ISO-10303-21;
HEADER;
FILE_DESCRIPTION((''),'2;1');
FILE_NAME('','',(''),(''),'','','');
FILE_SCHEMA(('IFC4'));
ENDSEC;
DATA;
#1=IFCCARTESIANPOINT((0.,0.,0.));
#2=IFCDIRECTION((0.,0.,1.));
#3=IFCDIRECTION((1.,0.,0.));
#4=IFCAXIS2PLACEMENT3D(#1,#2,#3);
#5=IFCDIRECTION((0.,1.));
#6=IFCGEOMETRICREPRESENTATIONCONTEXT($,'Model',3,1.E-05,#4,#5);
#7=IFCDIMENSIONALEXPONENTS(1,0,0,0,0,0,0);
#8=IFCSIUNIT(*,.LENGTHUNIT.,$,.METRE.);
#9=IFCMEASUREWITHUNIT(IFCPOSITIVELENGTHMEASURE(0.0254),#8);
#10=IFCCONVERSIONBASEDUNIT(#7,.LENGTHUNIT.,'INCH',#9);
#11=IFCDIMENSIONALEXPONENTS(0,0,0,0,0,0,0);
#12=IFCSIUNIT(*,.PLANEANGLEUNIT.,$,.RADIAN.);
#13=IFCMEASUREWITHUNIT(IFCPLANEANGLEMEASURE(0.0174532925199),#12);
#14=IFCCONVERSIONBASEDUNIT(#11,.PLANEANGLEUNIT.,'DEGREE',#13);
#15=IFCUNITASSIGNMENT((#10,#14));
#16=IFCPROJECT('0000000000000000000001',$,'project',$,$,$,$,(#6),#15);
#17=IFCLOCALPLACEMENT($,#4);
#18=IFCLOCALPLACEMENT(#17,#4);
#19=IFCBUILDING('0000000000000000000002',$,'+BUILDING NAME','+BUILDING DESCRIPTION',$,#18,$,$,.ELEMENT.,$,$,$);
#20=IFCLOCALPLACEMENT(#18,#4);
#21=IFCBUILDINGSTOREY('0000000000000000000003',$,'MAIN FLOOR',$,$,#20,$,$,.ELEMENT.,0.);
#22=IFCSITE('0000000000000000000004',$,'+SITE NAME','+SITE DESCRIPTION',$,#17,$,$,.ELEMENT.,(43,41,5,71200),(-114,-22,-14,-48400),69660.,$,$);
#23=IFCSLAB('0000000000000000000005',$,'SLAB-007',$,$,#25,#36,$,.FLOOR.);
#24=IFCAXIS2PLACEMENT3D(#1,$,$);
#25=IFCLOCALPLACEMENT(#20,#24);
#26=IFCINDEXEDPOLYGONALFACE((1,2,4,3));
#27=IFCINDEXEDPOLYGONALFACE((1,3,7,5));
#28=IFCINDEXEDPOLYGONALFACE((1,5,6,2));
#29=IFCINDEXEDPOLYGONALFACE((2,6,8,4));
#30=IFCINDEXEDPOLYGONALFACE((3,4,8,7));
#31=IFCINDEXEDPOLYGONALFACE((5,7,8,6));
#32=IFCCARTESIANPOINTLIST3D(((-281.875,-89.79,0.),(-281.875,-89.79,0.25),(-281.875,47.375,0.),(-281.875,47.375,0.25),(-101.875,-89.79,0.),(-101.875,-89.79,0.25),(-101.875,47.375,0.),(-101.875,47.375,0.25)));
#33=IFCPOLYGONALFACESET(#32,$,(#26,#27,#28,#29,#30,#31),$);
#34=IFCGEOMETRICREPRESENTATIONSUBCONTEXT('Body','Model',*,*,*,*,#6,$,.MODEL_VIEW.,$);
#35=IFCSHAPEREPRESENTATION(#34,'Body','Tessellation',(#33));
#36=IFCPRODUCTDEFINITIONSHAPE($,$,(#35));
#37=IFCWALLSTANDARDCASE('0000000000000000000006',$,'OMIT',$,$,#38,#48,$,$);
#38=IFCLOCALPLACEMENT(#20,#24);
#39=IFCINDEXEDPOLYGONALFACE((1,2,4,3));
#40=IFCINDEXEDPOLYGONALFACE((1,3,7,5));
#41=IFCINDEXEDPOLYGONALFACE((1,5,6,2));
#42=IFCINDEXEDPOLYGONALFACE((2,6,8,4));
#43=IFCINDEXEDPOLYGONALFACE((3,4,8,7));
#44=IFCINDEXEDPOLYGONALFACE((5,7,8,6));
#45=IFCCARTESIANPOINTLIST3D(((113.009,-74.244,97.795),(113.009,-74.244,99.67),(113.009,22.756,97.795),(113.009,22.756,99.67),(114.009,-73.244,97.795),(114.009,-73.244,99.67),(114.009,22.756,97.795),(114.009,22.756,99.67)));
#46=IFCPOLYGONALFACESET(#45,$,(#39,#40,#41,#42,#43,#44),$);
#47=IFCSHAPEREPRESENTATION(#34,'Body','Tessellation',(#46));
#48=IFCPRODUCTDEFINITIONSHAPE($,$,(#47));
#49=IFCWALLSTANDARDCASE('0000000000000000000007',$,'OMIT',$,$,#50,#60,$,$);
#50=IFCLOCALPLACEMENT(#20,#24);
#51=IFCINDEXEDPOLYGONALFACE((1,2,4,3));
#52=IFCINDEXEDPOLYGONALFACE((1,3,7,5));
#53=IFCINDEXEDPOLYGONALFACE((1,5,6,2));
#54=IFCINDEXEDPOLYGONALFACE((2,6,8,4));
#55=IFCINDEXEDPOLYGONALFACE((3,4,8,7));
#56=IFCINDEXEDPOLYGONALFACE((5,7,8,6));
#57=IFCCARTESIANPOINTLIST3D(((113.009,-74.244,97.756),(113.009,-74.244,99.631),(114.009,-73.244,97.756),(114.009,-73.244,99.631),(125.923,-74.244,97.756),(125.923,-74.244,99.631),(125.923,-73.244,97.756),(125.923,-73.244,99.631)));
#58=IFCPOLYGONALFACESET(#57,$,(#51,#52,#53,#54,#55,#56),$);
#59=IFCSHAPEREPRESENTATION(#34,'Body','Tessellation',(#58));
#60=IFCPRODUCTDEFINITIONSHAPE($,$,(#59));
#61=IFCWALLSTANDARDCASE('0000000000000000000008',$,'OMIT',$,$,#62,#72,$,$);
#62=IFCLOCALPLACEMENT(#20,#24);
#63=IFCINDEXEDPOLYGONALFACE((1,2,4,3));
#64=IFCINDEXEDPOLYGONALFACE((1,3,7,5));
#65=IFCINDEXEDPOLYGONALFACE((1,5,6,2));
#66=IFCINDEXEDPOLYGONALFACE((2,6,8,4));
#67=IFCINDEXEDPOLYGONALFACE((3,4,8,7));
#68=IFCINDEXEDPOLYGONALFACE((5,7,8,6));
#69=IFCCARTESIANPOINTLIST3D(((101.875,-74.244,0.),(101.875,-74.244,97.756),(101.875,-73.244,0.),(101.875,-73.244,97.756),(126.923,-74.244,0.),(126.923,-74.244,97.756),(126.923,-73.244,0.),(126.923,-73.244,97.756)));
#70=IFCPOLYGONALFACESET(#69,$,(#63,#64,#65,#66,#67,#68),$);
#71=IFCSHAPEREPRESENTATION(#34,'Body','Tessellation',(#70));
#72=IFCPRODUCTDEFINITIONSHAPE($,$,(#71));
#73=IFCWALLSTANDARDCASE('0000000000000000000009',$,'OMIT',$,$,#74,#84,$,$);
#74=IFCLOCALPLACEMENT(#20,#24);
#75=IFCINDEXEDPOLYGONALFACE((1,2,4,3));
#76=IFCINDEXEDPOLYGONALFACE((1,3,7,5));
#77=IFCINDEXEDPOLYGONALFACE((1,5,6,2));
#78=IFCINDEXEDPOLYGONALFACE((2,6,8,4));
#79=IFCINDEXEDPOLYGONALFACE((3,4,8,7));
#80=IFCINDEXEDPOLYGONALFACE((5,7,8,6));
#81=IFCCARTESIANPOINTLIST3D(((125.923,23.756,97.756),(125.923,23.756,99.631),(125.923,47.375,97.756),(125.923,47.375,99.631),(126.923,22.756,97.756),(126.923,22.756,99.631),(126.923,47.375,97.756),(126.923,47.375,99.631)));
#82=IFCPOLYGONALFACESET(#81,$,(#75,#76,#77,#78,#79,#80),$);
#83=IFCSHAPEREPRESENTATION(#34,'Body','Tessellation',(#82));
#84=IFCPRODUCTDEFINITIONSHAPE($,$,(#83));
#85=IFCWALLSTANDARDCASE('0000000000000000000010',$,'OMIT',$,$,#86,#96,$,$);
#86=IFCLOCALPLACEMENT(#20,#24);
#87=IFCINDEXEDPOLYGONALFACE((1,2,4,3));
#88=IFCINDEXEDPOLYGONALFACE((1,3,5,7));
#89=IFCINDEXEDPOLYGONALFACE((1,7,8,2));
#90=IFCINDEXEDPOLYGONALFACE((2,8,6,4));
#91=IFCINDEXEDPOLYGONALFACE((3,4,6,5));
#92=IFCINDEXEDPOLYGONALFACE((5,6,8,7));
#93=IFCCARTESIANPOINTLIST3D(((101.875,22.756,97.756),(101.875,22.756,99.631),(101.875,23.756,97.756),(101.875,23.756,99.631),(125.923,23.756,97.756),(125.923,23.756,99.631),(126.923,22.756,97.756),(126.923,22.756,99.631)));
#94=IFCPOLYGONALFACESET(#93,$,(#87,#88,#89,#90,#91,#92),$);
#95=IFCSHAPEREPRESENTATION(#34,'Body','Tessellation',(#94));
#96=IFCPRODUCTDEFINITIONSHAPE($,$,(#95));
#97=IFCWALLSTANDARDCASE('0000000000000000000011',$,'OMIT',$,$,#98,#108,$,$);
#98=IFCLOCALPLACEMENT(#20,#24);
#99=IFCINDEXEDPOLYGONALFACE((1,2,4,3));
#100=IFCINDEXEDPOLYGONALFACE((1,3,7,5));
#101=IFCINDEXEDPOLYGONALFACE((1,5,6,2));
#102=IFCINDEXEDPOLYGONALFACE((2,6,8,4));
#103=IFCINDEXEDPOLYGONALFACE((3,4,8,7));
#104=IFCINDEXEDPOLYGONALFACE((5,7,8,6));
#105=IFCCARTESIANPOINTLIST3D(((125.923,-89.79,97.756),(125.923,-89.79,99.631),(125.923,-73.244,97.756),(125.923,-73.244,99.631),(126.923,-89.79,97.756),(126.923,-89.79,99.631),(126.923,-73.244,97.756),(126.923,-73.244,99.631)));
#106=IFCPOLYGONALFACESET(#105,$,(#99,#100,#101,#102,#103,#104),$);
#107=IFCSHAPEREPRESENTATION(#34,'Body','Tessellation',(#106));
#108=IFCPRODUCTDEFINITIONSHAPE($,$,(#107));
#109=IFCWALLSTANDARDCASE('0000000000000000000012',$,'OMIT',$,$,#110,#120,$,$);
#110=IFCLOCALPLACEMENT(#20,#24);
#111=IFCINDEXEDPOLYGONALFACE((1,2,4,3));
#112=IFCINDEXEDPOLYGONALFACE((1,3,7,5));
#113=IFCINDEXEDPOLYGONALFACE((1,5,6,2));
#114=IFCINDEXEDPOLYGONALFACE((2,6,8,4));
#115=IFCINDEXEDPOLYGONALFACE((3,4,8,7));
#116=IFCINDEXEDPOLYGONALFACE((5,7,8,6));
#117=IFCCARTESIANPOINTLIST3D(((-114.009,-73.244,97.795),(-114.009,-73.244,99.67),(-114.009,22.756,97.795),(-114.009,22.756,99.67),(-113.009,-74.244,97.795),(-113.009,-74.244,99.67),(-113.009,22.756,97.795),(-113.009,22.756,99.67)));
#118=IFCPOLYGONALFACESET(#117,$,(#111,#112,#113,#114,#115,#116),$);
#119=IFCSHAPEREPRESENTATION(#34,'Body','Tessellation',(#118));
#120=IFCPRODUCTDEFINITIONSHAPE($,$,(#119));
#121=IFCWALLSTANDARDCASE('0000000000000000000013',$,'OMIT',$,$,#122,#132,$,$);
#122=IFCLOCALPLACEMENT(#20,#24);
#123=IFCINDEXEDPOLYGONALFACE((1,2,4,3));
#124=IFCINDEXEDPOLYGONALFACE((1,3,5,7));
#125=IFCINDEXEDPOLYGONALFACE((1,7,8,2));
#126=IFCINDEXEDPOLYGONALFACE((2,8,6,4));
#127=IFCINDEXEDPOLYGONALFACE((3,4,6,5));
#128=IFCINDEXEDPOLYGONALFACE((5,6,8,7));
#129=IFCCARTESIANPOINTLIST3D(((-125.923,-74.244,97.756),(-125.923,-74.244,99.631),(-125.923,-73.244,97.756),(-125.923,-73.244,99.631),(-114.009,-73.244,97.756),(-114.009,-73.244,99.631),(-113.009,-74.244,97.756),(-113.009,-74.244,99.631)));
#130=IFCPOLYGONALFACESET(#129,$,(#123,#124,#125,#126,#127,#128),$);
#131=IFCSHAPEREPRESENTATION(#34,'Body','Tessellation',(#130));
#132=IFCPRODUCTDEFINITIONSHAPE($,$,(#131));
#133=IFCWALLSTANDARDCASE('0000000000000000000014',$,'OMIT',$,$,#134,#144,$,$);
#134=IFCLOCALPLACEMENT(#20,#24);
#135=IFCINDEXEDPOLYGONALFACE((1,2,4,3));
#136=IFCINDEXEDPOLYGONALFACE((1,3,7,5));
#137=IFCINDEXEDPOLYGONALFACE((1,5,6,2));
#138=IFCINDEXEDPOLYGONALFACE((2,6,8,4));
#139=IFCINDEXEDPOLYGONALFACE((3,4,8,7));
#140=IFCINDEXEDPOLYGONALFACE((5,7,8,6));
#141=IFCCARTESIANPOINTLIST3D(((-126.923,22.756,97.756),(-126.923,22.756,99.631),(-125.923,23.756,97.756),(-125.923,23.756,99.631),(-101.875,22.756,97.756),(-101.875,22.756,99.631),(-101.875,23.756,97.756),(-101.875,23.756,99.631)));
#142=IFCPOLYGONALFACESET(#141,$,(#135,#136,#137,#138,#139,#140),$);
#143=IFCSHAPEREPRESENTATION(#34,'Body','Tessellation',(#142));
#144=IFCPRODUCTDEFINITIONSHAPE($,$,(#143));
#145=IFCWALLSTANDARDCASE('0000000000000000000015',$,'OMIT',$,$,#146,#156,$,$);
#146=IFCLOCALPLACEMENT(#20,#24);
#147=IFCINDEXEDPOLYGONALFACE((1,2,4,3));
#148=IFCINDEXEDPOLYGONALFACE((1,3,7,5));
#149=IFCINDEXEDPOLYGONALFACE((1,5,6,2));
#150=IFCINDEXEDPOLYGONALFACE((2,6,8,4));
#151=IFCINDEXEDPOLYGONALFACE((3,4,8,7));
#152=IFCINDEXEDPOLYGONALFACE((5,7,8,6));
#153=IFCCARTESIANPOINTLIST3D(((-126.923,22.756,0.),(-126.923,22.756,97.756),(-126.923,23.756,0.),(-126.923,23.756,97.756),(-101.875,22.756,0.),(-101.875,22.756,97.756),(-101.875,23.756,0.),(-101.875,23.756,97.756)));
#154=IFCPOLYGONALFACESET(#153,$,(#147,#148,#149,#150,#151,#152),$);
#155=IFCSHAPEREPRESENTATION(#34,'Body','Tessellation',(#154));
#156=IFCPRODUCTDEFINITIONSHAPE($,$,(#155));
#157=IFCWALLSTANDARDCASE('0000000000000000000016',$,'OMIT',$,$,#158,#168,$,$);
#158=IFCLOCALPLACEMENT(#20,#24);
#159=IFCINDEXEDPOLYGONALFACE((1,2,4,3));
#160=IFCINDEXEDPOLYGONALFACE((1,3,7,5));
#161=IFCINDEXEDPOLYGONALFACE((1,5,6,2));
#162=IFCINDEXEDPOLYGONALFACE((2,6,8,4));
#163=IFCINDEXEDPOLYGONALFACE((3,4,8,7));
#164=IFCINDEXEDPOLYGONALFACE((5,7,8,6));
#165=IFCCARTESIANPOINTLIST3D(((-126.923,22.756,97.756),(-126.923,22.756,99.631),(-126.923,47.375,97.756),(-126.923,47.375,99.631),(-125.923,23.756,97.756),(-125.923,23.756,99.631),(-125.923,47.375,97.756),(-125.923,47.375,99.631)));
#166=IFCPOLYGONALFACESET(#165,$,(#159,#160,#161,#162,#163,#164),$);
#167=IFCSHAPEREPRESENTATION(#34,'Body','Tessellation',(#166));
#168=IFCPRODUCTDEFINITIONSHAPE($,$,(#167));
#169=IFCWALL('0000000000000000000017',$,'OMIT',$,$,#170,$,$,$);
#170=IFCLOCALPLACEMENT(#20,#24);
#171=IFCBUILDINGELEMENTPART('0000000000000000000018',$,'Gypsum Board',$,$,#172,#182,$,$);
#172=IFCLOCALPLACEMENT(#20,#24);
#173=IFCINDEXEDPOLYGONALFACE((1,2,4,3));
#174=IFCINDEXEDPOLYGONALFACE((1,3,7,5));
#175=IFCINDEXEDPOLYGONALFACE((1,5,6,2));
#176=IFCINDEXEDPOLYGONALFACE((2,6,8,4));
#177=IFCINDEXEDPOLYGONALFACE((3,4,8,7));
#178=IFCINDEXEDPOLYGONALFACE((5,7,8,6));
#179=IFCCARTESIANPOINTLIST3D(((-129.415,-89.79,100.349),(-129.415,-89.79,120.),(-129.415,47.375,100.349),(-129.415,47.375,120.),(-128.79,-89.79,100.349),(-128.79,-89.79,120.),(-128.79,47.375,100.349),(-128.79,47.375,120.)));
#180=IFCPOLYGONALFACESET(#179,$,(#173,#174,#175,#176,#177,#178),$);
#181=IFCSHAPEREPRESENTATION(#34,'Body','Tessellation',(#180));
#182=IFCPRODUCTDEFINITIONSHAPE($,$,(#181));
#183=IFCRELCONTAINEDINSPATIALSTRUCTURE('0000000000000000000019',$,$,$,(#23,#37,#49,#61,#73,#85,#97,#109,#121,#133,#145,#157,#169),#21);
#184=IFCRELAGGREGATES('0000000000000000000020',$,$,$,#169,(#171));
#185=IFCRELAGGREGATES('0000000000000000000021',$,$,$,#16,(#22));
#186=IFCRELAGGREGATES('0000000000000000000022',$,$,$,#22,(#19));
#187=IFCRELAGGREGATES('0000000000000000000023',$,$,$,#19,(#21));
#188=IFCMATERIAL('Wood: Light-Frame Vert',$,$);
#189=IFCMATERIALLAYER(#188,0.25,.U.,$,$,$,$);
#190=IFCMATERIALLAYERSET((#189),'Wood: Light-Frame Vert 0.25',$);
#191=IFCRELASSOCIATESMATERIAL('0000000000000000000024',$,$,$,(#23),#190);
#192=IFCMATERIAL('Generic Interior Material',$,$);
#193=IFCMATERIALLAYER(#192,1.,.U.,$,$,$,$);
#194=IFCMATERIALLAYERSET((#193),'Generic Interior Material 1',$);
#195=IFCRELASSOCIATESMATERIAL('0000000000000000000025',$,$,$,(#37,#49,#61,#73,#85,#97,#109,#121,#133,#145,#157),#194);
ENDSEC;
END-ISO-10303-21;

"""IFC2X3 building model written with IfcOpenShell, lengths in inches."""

from ifc_helpers import new_model, entity, si_unit, converted_unit, direction, frame, origin_with_axes, place, context, subcontext, project, spatial, polyline, outline, extrude, material, layer, layer_set, layer_usage, element, aggregate, save


model = new_model("IFC2X3")

# Units and contexts
model_context = context("Model", 3, precision=1e-05, world=origin_with_axes(), true_north=direction((0.0, 1.0)))
body_context = subcontext(model_context, "Body", "Model", "MODEL_VIEW")
ifc_project = project(units=[converted_unit("LENGTHUNIT", "INCH", entity("IfcPositiveLengthMeasure", 0.0254), si_unit("LENGTHUNIT", "METRE"), dimensions=[1, 0, 0, 0, 0, 0, 0]), converted_unit("PLANEANGLEUNIT", "DEGREE", entity("IfcPlaneAngleMeasure", 0.0174532925199), si_unit("PLANEANGLEUNIT", "RADIAN"), dimensions=[0, 0, 0, 0, 0, 0, 0])], contexts=[model_context])

# Site, building, storey
site_placement = place(None, origin_with_axes())
site = spatial("IfcSite", under=ifc_project, at=site_placement, Name="+SITE NAME", Description="+SITE DESCRIPTION", CompositionType="ELEMENT", RefLatitude=(43, 41, 5, 71200), RefLongitude=(-114, -22, -14, -48400), RefElevation=69660.0)
building_placement = place(site_placement, origin_with_axes())
building = spatial("IfcBuilding", under=site, at=building_placement, Name="+BUILDING NAME", Description="+BUILDING DESCRIPTION", CompositionType="ELEMENT")
storey_placement = place(building_placement, origin_with_axes())
storey = spatial("IfcBuildingStorey", under=building, at=storey_placement, Name="MAIN FLOOR", CompositionType="ELEMENT", Elevation=0.0)

# Slab
ifc_material_1 = material(Name="Wood: Light-Frame Vert")
ifc_layer_1 = layer(ifc_material_1, 0.25, ventilated="UNKNOWN")
ifc_layer_set_1 = layer_set([ifc_layer_1], Name="Wood: Light-Frame Vert 0.25")
ifc_layer_usage_1 = layer_usage(ifc_layer_set_1, "AXIS3", "NEGATIVE", 0.25)
slab_placement = place(storey_placement, frame((-281.875, -89.79, 0.25), z_axis=(0.0, 0.0, 1.0), x_axis=(1.0, 0.0, 0.0)))
element("IfcSlab", 1, at=slab_placement, inside=storey, material=ifc_layer_usage_1, Name="SLAB-007", PredefinedType="FLOOR", context=body_context, shape_type="SweptSolid", body=[
    extrude(outline(polyline([(0.0, 0.0), (180.0, 0.0), (180.0, 137.165), (0.0, 137.165), (0.0, 0.0)])), frame((0.0, 0.0, -0.25), z_axis=(0.0, 0.0, 1.0), x_axis=(1.0, 0.0, 0.0)), (0.0, 0.0, 1.0), 0.25),
])

# Walls
ifc_material_2 = material(Name="Generic Interior Material")
ifc_layer_2 = layer(ifc_material_2, 1.0, ventilated="UNKNOWN")
ifc_layer_set_2 = layer_set([ifc_layer_2], Name="Generic Interior Material 1")
ifc_layer_usage_2 = layer_usage(ifc_layer_set_2, "AXIS2", "NEGATIVE", 0.0)
wall_1_placement = place(storey_placement, frame((114.009, 22.756, 97.795), z_axis=(0.0, 0.0, 1.0), x_axis=(0.0, -1.0, 0.0)))
element("IfcWallStandardCase", 2, at=wall_1_placement, inside=storey, material=ifc_layer_usage_2, Name="OMIT", context=body_context, shape_type="SweptSolid", body=[
    extrude(outline(polyline([(0.0, -1.0), (97.0, -1.0), (96.0, 0.0), (0.0, 0.0), (0.0, -1.0)])), origin_with_axes(), (0.0, 0.0, 1.0), 1.875),
])
ifc_layer_usage_3 = layer_usage(ifc_layer_set_2, "AXIS2", "NEGATIVE", 0.0)
wall_2_placement = place(storey_placement, frame((114.009, -73.244, 97.756), z_axis=(0.0, 0.0, 1.0), x_axis=(1.0, 0.0, 0.0)))
element("IfcWallStandardCase", 3, at=wall_2_placement, inside=storey, material=ifc_layer_usage_3, Name="OMIT", context=body_context, shape_type="SweptSolid", body=[
    extrude(outline(polyline([(-1.0, -1.0), (11.914, -1.0), (11.914, 0.0), (0.0, 0.0), (-1.0, -1.0)])), origin_with_axes(), (0.0, 0.0, 1.0), 1.875),
])
ifc_layer_usage_4 = layer_usage(ifc_layer_set_2, "AXIS2", "NEGATIVE", 0.0)
wall_3_placement = place(storey_placement, frame((126.923, -74.244, 0.0), z_axis=(0.0, 0.0, 1.0), x_axis=(-1.0, 0.0, 0.0)))
element("IfcWallStandardCase", 4, at=wall_3_placement, inside=storey, material=ifc_layer_usage_4, Name="OMIT", context=body_context, shape_type="SweptSolid", body=[
    extrude(outline(polyline([(0.0, -1.0), (25.048, -1.0), (25.048, 0.0), (0.0, 0.0), (0.0, -1.0)])), origin_with_axes(), (0.0, 0.0, 1.0), 97.756),
])
ifc_layer_usage_5 = layer_usage(ifc_layer_set_2, "AXIS2", "NEGATIVE", 0.0)
wall_4_placement = place(storey_placement, frame((126.923, 47.375, 97.756), z_axis=(0.0, 0.0, 1.0), x_axis=(0.0, -1.0, 0.0)))
element("IfcWallStandardCase", 5, at=wall_4_placement, inside=storey, material=ifc_layer_usage_5, Name="OMIT", context=body_context, shape_type="SweptSolid", body=[
    extrude(outline(polyline([(0.0, -1.0), (23.619, -1.0), (24.619, 0.0), (0.0, 0.0), (0.0, -1.0)])), origin_with_axes(), (0.0, 0.0, 1.0), 1.875),
])
ifc_layer_usage_6 = layer_usage(ifc_layer_set_2, "AXIS2", "NEGATIVE", 0.0)
wall_5_placement = place(storey_placement, frame((126.923, 22.756, 97.756), z_axis=(0.0, 0.0, 1.0), x_axis=(-1.0, 0.0, 0.0)))
element("IfcWallStandardCase", 6, at=wall_5_placement, inside=storey, material=ifc_layer_usage_6, Name="OMIT", context=body_context, shape_type="SweptSolid", body=[
    extrude(outline(polyline([(1.0, -1.0), (25.048, -1.0), (25.048, 0.0), (0.0, 0.0), (1.0, -1.0)])), origin_with_axes(), (0.0, 0.0, 1.0), 1.875),
])
ifc_layer_usage_7 = layer_usage(ifc_layer_set_2, "AXIS2", "NEGATIVE", 0.0)
wall_6_placement = place(storey_placement, frame((126.923, -73.244, 97.756), z_axis=(0.0, 0.0, 1.0), x_axis=(0.0, -1.0, 0.0)))
element("IfcWallStandardCase", 7, at=wall_6_placement, inside=storey, material=ifc_layer_usage_7, Name="OMIT", context=body_context, shape_type="SweptSolid", body=[
    extrude(outline(polyline([(0.0, -1.0), (16.546, -1.0), (16.546, 0.0), (0.0, 0.0), (0.0, -1.0)])), origin_with_axes(), (0.0, 0.0, 1.0), 1.875),
])
ifc_layer_usage_8 = layer_usage(ifc_layer_set_2, "AXIS2", "POSITIVE", 0.0)
wall_7_placement = place(storey_placement, frame((-114.009, 22.756, 97.795), z_axis=(0.0, 0.0, 1.0), x_axis=(0.0, -1.0, 0.0)))
element("IfcWallStandardCase", 8, at=wall_7_placement, inside=storey, material=ifc_layer_usage_8, Name="OMIT", context=body_context, shape_type="SweptSolid", body=[
    extrude(outline(polyline([(0.0, 0.0), (96.0, 0.0), (97.0, 1.0), (0.0, 1.0), (0.0, 0.0)])), origin_with_axes(), (0.0, 0.0, 1.0), 1.875),
])
ifc_layer_usage_9 = layer_usage(ifc_layer_set_2, "AXIS2", "POSITIVE", 0.0)
wall_8_placement = place(storey_placement, frame((-114.009, -73.244, 97.756), z_axis=(0.0, 0.0, 1.0), x_axis=(-1.0, 0.0, 0.0)))
element("IfcWallStandardCase", 9, at=wall_8_placement, inside=storey, material=ifc_layer_usage_9, Name="OMIT", context=body_context, shape_type="SweptSolid", body=[
    extrude(outline(polyline([(0.0, 0.0), (11.914, 0.0), (11.914, 1.0), (-1.0, 1.0), (0.0, 0.0)])), origin_with_axes(), (0.0, 0.0, 1.0), 1.875),
])
ifc_layer_usage_10 = layer_usage(ifc_layer_set_2, "AXIS2", "POSITIVE", 0.0)
wall_9_placement = place(storey_placement, frame((-126.923, 22.756, 97.756), z_axis=(0.0, 0.0, 1.0), x_axis=(1.0, 0.0, 0.0)))
element("IfcWallStandardCase", 10, at=wall_9_placement, inside=storey, material=ifc_layer_usage_10, Name="OMIT", context=body_context, shape_type="SweptSolid", body=[
    extrude(outline(polyline([(0.0, 0.0), (25.048, 0.0), (25.048, 1.0), (1.0, 1.0), (0.0, 0.0)])), origin_with_axes(), (0.0, 0.0, 1.0), 1.875),
])
ifc_layer_usage_11 = layer_usage(ifc_layer_set_2, "AXIS2", "POSITIVE", 0.0)
wall_10_placement = place(storey_placement, frame((-126.923, 22.756, 0.0), z_axis=(0.0, 0.0, 1.0), x_axis=(1.0, 0.0, 0.0)))
element("IfcWallStandardCase", 11, at=wall_10_placement, inside=storey, material=ifc_layer_usage_11, Name="OMIT", context=body_context, shape_type="SweptSolid", body=[
    extrude(outline(polyline([(0.0, 0.0), (25.048, 0.0), (25.048, 1.0), (0.0, 1.0), (0.0, 0.0)])), origin_with_axes(), (0.0, 0.0, 1.0), 97.756),
])
ifc_layer_usage_12 = layer_usage(ifc_layer_set_2, "AXIS2", "POSITIVE", 0.0)
wall_11_placement = place(storey_placement, frame((-126.923, 47.375, 97.756), z_axis=(0.0, 0.0, 1.0), x_axis=(0.0, -1.0, 0.0)))
element("IfcWallStandardCase", 12, at=wall_11_placement, inside=storey, material=ifc_layer_usage_12, Name="OMIT", context=body_context, shape_type="SweptSolid", body=[
    extrude(outline(polyline([(0.0, 0.0), (24.619, 0.0), (23.619, 1.0), (0.0, 1.0), (0.0, 0.0)])), origin_with_axes(), (0.0, 0.0, 1.0), 1.875),
])

# Wall, building element part
wall_12_placement = place(storey_placement, frame((-128.79, -89.79, 100.349), z_axis=(0.0, 0.0, 1.0), x_axis=(0.0, 1.0, 0.0)))
wall_12 = element("IfcWall", 13, at=wall_12_placement, inside=storey, Name="OMIT")
building_element_part_1_placement = place(wall_12_placement, origin_with_axes())
building_element_part_1 = element("IfcBuildingElementPart", 14, at=building_element_part_1_placement, Name="Gypsum Board", context=body_context, shape_type="SweptSolid", body=[
    extrude(outline(polyline([(0.0, 0.0), (137.165, 0.0), (137.165, 0.625), (0.0, 0.625), (0.0, 0.0)])), origin_with_axes(), (0.0, 0.0, 1.0), 19.651),
])
aggregate(wall_12, [building_element_part_1])

save(model, "model.ifc")
